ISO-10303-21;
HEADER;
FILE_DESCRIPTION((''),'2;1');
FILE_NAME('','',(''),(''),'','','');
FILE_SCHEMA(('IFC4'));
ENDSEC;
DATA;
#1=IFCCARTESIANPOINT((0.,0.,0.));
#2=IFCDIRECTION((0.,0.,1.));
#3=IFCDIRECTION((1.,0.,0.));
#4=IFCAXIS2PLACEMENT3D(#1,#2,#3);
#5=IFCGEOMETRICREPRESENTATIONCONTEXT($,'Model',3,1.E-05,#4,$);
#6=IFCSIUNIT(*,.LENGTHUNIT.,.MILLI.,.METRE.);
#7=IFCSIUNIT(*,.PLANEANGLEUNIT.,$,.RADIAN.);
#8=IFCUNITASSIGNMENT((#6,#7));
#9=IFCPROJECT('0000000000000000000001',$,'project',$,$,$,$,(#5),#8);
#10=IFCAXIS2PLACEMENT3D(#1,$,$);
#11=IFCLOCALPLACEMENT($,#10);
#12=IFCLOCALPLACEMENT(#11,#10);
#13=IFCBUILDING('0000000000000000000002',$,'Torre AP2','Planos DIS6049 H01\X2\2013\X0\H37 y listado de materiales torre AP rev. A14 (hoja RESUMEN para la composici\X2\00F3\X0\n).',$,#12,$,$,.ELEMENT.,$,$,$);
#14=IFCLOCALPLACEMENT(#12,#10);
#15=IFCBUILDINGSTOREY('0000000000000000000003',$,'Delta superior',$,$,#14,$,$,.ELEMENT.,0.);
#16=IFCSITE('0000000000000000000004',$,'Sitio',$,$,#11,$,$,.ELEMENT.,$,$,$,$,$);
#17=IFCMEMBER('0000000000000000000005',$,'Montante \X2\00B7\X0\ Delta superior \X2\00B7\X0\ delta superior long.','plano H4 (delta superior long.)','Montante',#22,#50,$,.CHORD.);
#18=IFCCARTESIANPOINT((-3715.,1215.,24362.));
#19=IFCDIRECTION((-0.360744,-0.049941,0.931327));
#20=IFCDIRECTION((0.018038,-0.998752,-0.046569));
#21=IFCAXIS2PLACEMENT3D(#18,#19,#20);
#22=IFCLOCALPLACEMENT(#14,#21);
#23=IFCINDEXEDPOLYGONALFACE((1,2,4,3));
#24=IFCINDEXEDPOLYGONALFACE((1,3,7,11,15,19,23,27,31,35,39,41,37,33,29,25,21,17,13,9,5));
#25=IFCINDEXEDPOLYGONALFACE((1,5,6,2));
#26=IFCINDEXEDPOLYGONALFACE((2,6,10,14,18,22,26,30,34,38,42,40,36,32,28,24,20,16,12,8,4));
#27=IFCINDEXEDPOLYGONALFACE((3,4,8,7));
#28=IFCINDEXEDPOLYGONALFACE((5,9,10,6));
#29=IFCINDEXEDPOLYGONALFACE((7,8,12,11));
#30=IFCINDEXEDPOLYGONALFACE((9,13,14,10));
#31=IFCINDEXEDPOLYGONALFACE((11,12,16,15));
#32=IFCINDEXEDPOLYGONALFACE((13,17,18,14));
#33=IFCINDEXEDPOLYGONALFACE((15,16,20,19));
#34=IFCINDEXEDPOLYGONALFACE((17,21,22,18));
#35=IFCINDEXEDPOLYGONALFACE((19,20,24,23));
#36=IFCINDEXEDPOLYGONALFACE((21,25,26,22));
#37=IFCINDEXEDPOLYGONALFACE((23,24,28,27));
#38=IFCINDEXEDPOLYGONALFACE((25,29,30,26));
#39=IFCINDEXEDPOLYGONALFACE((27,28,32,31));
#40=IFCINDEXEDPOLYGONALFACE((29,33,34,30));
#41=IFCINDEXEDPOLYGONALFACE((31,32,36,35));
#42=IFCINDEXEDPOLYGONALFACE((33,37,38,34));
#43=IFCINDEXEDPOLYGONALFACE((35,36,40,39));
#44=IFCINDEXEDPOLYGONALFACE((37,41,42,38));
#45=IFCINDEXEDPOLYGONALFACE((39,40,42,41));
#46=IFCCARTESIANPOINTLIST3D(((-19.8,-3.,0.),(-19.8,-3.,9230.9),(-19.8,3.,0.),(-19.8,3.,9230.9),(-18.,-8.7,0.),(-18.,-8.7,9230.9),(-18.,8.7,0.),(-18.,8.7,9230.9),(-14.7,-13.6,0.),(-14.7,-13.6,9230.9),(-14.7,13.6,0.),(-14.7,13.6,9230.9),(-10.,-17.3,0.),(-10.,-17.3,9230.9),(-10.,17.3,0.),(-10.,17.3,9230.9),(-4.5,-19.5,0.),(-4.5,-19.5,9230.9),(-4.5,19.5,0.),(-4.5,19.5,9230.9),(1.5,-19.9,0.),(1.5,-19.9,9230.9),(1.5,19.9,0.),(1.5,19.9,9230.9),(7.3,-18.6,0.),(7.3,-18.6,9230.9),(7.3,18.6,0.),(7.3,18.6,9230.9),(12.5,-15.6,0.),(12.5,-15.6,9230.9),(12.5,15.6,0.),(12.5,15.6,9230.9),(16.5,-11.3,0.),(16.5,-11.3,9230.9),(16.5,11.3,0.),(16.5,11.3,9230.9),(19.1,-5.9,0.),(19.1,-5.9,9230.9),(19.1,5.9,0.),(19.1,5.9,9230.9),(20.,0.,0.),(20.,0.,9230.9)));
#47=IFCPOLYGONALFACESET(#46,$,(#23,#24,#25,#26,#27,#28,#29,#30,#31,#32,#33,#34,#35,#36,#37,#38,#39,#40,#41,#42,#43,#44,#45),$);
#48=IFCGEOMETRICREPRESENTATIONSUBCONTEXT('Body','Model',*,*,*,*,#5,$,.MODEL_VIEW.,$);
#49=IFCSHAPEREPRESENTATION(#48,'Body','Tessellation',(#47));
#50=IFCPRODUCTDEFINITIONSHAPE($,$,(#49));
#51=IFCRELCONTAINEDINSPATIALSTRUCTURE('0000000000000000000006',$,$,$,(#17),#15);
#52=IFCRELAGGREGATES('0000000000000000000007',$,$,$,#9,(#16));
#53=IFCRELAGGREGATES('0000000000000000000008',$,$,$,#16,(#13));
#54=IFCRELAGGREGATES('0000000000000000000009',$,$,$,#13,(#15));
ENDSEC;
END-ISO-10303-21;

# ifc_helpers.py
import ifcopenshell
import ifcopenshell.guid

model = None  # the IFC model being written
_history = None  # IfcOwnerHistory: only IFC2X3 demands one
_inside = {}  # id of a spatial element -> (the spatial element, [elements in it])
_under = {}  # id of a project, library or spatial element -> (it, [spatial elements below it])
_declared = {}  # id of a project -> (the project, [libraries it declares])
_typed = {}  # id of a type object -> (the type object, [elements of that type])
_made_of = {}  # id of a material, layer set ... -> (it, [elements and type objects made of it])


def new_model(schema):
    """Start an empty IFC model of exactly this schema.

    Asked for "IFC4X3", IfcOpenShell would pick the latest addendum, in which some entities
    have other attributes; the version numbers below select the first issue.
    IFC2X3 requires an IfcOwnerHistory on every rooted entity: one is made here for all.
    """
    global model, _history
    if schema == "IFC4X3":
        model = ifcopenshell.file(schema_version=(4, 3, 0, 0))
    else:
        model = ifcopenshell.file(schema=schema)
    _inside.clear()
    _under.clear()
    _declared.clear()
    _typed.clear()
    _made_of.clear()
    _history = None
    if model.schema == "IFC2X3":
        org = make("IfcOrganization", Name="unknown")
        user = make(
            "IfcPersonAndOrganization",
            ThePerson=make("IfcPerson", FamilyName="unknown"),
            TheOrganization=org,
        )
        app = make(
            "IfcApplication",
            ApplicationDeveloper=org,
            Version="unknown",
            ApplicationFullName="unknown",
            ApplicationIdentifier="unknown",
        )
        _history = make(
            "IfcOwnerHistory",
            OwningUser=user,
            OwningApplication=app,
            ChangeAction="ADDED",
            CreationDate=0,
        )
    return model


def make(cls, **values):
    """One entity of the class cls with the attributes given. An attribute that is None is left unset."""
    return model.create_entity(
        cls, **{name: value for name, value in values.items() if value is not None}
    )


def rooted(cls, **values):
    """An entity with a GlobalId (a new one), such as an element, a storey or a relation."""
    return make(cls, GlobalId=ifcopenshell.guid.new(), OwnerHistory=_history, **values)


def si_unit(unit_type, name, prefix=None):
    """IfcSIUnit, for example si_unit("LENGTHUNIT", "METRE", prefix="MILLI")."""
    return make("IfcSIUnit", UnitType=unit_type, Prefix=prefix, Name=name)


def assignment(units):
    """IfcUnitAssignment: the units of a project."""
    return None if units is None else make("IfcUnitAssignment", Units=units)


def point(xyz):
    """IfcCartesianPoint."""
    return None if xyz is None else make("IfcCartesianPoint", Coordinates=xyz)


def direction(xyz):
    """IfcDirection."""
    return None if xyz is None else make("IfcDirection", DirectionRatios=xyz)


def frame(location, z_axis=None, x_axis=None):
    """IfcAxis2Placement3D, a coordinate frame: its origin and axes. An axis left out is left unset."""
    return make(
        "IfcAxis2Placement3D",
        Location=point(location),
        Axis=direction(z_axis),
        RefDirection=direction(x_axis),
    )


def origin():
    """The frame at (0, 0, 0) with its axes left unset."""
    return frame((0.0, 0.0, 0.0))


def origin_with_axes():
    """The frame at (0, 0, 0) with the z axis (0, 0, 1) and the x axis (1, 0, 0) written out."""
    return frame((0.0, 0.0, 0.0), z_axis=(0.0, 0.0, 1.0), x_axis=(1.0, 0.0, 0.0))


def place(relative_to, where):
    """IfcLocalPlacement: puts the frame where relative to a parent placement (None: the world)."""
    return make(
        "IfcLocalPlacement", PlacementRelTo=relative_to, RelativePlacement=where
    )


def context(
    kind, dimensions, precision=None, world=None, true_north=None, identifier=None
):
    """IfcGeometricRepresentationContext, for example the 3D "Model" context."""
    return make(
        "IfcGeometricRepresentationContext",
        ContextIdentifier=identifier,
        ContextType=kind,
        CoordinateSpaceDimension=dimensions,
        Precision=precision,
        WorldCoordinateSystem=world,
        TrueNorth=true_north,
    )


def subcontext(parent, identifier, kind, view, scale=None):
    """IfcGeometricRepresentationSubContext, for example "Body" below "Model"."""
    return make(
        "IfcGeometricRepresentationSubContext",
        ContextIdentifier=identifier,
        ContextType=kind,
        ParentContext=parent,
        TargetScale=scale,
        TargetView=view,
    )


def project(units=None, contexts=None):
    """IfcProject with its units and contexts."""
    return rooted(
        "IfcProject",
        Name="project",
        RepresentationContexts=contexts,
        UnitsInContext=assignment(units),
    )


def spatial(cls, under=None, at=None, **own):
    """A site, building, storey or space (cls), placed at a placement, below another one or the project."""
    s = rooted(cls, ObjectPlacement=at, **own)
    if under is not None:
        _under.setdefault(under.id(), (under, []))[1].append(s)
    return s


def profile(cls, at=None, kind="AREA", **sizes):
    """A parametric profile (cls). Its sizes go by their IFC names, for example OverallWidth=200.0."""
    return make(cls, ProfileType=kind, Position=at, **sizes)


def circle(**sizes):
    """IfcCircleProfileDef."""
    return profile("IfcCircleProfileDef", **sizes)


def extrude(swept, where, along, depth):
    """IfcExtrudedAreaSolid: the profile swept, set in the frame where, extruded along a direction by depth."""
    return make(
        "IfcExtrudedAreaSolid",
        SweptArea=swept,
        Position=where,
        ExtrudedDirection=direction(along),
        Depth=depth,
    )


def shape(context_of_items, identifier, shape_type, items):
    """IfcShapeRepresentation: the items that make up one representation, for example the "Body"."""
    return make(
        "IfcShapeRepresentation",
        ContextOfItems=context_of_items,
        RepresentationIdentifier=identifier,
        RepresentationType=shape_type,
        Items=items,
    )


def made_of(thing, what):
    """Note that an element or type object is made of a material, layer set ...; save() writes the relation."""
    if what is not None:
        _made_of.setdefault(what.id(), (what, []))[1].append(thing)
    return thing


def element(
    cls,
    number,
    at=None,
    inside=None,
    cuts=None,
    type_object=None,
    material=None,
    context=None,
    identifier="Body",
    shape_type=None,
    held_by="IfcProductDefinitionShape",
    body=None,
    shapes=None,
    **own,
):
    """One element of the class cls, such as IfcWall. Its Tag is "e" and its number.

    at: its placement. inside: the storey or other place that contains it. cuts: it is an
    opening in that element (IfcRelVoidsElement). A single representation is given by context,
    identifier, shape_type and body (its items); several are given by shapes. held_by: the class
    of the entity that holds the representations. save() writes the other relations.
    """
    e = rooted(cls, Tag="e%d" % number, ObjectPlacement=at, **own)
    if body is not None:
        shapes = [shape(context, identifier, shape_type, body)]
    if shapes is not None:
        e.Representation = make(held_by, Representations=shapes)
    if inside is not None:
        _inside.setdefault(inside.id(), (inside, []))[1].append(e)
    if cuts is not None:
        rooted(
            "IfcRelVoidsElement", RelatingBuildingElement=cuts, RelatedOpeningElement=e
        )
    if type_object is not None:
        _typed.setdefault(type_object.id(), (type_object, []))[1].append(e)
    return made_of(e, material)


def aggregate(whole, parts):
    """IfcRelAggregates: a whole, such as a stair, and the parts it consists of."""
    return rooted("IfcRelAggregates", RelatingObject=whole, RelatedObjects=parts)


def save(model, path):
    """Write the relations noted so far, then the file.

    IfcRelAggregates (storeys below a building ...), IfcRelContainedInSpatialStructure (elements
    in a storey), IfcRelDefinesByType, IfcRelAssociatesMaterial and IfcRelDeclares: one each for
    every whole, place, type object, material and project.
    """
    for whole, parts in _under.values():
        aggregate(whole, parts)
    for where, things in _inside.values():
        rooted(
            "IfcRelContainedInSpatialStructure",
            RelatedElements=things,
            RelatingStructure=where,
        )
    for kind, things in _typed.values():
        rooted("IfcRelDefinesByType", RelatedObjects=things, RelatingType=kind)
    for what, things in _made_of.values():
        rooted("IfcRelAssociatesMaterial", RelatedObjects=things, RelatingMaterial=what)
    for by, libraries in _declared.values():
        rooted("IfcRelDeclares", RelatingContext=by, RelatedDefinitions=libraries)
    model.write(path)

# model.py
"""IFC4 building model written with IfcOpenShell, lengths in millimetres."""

from ifc_helpers import new_model, si_unit, frame, origin, origin_with_axes, place, context, subcontext, project, spatial, circle, extrude, element, save


model = new_model("IFC4")

# Units and contexts
model_context = context("Model", 3, precision=1e-05, world=origin_with_axes())
body_context = subcontext(model_context, "Body", "Model", "MODEL_VIEW")
ifc_project = project(units=[si_unit("LENGTHUNIT", "METRE", prefix="MILLI"), si_unit("PLANEANGLEUNIT", "RADIAN")], contexts=[model_context])

# Site, building, storey
site_placement = place(None, origin())
site = spatial("IfcSite", under=ifc_project, at=site_placement, Name="Sitio", CompositionType="ELEMENT")
building_placement = place(site_placement, origin())
building = spatial("IfcBuilding", under=site, at=building_placement, Name="Torre AP2", Description="Planos DIS6049 H01–H37 y listado de materiales torre AP rev. A14 (hoja RESUMEN para la composición).", CompositionType="ELEMENT")
storey_placement = place(building_placement, origin())
storey = spatial("IfcBuildingStorey", under=building, at=storey_placement, Name="Delta superior", CompositionType="ELEMENT", Elevation=0.0)

# Member
for number, where, z_axis, x_axis, name in (
    (1, (-3715.0, 1215.0, 24362.0), (-0.360744, -0.049941, 0.931327), (0.018038, -0.998752, -0.046569), "Montante · Delta superior · delta superior long."),
):
    element("IfcMember", number, at=place(storey_placement, frame(where, z_axis=z_axis, x_axis=x_axis)), inside=storey, Name=name, Description="plano H4 (delta superior long.)", ObjectType="Montante", PredefinedType="CHORD", context=body_context, shape_type="SweptSolid", body=[
        extrude(circle(Radius=20.0), None, (0.0, 0.0, 1.0), 9230.9),
    ])

save(model, "model.ifc")
